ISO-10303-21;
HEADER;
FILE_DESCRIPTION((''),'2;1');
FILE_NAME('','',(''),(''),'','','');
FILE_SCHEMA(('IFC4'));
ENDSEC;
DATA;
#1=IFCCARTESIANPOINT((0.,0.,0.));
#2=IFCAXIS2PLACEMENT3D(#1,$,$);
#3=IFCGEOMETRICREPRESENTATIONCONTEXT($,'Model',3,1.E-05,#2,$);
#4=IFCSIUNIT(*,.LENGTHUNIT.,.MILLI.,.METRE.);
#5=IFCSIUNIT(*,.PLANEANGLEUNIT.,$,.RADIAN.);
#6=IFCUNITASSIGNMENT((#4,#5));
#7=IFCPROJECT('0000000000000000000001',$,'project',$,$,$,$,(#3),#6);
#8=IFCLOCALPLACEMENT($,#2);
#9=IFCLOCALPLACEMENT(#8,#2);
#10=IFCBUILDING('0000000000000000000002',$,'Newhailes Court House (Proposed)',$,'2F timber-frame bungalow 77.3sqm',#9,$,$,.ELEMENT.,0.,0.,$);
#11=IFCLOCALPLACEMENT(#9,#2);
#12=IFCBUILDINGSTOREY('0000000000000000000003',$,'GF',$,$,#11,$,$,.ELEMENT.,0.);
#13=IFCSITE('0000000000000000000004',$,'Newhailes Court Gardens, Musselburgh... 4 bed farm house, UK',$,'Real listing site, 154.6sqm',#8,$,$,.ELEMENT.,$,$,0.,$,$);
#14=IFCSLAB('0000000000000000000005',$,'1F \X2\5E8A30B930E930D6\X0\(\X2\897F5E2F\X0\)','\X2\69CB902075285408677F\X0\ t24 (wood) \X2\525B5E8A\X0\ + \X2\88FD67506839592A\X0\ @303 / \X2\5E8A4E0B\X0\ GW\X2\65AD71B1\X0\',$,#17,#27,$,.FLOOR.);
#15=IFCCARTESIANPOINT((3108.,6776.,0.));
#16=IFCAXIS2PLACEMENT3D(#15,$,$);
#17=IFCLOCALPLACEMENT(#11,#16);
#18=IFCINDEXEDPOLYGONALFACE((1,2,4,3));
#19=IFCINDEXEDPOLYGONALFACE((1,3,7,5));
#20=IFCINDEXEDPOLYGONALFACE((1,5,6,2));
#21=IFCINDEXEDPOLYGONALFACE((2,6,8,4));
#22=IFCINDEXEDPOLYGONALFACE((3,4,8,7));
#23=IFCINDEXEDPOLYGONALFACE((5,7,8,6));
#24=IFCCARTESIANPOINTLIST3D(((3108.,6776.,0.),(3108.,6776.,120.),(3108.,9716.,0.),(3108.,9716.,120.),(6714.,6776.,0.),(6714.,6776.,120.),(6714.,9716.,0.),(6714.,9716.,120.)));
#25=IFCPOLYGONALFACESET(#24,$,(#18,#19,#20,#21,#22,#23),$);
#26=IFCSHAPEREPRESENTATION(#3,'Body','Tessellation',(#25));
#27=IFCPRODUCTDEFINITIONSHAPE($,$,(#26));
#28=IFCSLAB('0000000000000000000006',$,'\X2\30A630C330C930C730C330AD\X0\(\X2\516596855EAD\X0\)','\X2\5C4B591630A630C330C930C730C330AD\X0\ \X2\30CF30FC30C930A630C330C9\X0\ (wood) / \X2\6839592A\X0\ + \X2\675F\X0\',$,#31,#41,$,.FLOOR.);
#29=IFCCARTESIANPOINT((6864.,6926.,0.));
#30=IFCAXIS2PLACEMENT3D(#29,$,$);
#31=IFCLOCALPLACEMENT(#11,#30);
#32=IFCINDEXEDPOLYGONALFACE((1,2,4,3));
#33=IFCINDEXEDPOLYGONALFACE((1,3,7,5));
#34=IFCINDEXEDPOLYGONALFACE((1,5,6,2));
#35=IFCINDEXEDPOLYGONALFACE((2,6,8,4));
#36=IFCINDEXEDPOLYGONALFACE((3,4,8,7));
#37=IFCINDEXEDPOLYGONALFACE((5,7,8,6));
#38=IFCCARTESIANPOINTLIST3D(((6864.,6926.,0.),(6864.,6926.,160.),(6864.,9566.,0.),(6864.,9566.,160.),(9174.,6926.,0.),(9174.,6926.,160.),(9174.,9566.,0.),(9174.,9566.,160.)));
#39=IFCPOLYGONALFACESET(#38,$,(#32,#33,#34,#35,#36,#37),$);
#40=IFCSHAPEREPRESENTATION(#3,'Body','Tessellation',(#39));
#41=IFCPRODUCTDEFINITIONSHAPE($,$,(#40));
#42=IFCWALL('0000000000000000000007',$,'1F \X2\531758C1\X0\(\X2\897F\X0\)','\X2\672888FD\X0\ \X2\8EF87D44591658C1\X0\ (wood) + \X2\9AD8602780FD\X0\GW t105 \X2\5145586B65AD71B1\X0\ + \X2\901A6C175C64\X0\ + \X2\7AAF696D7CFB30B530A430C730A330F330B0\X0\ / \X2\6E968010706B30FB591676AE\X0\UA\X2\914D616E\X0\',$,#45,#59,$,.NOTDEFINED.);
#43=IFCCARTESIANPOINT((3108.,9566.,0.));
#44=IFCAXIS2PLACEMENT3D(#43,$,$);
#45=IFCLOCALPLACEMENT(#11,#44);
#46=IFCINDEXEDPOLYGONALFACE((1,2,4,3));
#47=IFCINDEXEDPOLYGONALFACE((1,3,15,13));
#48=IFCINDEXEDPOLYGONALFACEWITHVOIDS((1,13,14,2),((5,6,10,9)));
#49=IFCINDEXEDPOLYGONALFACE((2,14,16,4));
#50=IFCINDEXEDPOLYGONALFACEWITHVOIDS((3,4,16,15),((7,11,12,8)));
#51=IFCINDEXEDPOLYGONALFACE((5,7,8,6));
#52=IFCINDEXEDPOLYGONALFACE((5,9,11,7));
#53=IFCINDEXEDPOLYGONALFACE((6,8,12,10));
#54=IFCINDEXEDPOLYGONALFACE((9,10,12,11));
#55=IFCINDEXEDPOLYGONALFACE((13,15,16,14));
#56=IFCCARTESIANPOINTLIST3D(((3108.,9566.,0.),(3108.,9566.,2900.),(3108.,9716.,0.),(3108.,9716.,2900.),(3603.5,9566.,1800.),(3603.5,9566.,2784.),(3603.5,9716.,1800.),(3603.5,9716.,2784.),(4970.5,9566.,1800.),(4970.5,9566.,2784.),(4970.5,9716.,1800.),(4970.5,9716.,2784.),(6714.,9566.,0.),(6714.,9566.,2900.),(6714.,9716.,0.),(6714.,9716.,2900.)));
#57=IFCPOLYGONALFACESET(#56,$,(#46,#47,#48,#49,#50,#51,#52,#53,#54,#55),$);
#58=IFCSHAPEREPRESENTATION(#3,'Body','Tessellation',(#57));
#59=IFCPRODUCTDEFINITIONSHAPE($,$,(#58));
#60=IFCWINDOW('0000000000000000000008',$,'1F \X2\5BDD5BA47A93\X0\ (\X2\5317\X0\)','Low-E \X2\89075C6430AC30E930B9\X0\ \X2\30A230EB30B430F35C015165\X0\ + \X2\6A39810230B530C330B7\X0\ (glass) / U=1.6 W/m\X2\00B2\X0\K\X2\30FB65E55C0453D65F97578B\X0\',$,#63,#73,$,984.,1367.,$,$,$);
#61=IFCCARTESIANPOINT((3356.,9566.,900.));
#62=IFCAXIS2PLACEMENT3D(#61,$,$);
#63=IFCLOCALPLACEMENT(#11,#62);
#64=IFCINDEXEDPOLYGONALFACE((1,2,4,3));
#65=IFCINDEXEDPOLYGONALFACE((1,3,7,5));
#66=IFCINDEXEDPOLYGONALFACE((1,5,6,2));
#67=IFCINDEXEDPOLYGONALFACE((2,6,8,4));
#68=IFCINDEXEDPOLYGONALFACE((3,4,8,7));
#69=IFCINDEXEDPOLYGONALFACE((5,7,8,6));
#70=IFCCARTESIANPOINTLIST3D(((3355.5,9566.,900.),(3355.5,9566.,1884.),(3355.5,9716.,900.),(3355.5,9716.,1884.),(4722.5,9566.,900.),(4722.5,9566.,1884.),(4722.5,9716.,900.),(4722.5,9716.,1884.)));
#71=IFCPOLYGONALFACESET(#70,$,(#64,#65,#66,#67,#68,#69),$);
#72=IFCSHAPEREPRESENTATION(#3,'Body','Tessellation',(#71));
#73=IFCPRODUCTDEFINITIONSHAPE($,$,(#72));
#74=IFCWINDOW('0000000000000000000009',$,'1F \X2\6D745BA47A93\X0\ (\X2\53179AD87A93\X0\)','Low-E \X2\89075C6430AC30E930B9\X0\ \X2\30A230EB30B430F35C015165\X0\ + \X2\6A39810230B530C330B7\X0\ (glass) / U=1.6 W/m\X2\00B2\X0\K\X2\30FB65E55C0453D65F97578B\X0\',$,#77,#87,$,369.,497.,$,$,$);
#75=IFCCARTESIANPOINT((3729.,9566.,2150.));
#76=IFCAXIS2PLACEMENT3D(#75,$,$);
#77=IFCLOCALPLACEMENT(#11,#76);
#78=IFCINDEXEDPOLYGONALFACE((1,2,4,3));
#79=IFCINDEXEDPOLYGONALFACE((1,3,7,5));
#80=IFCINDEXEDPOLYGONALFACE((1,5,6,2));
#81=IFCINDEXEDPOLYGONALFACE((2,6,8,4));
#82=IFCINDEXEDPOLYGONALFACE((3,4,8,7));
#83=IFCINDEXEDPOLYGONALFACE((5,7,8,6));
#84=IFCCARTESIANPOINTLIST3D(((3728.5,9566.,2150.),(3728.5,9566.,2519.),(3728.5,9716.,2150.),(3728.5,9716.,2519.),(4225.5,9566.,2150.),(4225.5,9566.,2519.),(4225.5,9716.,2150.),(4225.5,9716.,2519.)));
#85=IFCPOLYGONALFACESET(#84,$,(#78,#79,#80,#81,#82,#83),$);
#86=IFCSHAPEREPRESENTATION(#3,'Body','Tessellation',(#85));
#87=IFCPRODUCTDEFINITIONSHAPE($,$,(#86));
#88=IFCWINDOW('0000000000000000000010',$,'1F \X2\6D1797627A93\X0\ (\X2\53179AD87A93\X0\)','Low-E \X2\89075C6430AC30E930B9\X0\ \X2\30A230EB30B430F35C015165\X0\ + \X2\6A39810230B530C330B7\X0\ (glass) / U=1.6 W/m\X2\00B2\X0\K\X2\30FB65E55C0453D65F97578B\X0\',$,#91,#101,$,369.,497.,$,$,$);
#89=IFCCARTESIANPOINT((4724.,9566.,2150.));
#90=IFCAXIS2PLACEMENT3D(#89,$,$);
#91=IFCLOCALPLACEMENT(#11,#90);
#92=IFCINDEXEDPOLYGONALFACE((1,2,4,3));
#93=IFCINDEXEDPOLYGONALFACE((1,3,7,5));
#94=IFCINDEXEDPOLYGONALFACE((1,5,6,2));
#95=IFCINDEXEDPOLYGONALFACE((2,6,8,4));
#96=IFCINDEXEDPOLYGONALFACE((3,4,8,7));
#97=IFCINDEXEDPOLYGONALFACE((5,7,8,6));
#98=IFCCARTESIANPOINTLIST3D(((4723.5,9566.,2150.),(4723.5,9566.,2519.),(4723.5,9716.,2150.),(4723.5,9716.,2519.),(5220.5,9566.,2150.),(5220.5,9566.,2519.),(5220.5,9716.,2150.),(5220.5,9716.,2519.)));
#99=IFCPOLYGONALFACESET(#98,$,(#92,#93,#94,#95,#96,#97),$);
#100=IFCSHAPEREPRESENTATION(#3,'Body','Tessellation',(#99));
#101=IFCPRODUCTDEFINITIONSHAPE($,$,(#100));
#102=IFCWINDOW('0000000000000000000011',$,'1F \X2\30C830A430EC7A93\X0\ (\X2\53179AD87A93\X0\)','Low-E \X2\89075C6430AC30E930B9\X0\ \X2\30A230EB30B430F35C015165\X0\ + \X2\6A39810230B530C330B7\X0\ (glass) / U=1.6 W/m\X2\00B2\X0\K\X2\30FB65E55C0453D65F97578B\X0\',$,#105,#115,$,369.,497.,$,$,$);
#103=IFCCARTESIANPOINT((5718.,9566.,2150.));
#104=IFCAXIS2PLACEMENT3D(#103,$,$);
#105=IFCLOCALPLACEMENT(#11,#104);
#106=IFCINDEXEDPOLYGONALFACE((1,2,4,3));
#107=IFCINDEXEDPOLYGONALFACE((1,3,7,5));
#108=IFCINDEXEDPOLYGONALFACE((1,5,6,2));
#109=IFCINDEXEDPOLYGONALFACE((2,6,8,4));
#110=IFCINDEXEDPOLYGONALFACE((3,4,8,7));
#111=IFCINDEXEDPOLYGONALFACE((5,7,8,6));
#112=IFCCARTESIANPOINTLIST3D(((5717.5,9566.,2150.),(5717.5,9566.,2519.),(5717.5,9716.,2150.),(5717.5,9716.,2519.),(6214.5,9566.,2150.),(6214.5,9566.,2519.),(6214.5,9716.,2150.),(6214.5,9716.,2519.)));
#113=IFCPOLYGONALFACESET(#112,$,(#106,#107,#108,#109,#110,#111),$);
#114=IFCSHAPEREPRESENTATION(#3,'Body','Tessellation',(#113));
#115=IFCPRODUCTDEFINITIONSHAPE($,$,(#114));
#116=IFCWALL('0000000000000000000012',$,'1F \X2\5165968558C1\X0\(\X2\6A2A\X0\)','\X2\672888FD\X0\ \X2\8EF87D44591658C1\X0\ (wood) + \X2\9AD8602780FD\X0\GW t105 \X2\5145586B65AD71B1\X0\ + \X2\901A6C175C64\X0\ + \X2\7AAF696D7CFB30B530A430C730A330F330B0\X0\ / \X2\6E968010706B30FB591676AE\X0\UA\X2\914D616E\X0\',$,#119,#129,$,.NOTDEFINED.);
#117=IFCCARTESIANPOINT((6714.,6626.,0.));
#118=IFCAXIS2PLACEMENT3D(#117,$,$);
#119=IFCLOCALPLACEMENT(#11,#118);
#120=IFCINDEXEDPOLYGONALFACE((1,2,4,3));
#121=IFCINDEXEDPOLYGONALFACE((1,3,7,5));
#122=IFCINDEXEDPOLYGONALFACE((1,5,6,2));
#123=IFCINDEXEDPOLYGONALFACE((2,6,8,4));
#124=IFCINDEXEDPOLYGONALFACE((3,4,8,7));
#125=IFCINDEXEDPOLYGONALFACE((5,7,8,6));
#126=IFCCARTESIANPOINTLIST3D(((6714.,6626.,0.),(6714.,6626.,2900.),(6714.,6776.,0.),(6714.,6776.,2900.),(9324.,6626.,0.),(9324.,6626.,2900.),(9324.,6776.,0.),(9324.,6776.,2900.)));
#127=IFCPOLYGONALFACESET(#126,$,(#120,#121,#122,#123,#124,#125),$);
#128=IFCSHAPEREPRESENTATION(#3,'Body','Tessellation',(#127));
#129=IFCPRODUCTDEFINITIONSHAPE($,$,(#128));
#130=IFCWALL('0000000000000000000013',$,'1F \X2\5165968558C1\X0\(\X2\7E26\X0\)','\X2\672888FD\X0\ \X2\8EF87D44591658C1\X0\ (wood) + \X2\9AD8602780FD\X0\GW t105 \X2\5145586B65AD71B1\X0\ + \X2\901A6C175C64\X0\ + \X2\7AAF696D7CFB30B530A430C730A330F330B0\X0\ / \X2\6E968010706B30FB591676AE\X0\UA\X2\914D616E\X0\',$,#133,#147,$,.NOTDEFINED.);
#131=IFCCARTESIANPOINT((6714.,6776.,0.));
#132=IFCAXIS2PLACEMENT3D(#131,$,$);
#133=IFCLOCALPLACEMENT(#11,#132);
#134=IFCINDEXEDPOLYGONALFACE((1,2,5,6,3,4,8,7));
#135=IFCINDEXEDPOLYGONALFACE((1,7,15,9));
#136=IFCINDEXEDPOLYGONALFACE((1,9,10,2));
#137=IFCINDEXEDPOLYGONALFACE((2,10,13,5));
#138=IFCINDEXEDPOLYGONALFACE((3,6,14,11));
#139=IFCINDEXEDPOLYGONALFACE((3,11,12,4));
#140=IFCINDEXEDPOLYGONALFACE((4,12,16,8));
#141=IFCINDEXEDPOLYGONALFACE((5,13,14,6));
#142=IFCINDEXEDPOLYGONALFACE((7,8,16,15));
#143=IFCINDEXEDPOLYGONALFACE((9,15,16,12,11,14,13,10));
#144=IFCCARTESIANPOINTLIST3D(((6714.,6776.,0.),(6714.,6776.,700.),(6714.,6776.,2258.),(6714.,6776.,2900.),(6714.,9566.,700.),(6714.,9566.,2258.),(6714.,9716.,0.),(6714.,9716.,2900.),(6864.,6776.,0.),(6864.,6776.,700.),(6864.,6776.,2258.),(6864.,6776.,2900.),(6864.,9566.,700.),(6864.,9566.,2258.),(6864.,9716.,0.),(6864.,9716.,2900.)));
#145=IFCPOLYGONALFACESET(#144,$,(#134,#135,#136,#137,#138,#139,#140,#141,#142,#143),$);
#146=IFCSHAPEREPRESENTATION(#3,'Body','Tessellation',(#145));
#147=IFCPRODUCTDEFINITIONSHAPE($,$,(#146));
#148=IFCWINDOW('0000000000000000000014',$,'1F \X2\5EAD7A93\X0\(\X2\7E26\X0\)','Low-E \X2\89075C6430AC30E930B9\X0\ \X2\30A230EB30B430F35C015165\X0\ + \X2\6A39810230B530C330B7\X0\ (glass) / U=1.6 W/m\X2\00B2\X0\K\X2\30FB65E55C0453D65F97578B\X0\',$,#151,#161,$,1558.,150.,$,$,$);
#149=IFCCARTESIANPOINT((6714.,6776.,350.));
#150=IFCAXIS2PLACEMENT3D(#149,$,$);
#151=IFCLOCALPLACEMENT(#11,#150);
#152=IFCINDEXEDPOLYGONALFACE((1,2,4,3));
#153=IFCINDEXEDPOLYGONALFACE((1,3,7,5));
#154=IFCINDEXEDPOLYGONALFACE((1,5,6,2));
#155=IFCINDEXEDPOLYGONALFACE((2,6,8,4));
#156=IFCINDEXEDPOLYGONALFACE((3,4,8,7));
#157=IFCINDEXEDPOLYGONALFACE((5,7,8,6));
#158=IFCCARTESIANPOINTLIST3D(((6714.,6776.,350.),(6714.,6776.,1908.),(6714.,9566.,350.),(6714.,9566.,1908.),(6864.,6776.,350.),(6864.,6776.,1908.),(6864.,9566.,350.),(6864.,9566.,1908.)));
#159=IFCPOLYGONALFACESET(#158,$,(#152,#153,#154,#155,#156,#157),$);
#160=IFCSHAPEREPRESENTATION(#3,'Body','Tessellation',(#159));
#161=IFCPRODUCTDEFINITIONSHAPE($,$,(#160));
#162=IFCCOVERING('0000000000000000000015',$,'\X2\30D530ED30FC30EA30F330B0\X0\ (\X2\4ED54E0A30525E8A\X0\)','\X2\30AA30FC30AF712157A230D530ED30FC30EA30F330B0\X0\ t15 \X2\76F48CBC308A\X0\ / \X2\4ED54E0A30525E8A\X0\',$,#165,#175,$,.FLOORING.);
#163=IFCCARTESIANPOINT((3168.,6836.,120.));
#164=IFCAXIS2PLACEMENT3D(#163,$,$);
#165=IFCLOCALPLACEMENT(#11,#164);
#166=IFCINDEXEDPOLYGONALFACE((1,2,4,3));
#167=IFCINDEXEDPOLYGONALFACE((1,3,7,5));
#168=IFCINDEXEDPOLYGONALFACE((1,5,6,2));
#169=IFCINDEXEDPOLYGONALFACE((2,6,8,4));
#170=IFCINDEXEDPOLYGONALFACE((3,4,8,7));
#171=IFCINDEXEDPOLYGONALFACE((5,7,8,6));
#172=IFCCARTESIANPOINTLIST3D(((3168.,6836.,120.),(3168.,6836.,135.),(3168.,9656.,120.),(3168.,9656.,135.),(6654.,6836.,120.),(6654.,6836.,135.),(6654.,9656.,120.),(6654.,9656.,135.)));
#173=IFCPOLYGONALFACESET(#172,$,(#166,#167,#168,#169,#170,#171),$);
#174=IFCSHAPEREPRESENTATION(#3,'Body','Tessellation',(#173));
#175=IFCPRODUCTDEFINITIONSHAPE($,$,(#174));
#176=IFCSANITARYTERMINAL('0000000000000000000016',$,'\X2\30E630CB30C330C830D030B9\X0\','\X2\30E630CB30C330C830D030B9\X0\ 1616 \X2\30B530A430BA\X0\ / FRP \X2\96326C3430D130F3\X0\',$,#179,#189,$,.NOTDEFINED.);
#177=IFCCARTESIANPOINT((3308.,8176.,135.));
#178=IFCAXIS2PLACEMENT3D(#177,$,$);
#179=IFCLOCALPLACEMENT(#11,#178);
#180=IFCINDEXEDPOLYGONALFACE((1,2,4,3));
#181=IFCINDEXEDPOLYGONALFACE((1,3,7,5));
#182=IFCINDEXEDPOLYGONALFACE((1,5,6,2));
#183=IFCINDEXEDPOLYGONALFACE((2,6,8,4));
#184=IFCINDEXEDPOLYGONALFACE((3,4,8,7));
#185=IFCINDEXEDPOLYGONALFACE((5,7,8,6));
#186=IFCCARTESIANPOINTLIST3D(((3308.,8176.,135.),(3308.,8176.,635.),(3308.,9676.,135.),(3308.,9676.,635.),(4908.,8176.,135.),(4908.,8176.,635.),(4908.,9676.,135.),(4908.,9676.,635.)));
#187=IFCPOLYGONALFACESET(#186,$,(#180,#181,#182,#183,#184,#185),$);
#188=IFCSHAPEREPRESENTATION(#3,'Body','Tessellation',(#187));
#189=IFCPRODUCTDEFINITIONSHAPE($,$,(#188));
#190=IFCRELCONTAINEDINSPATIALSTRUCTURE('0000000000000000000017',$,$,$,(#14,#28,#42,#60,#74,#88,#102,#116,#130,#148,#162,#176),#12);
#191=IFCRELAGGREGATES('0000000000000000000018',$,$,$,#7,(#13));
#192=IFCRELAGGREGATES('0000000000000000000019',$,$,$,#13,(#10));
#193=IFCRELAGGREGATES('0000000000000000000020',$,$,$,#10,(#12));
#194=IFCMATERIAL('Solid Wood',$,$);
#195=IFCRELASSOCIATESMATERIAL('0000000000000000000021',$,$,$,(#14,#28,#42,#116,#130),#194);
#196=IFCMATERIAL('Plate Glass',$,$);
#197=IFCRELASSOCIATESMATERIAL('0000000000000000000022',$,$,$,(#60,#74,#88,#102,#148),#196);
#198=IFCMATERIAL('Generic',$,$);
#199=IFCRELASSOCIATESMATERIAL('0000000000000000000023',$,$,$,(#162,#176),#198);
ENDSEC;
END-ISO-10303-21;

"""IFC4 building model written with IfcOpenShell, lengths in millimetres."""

from ifc_helpers import new_model, si_unit, frame, frame_2d, origin, place, context, project, spatial, rectangle, extrude, material, element, fill, save


model = new_model("IFC4")

# Units and contexts
model_context = context("Model", 3, precision=1e-05, world=origin())
ifc_project = project(units=[si_unit("LENGTHUNIT", "METRE", prefix="MILLI"), si_unit("PLANEANGLEUNIT", "RADIAN")], contexts=[model_context])

# Site, building, storey
site_placement = place(None, origin())
site = spatial("IfcSite", under=ifc_project, at=site_placement, Name="Newhailes Court Gardens, Musselburgh... 4 bed farm house, UK", ObjectType="Real listing site, 154.6sqm", CompositionType="ELEMENT", RefElevation=0.0)
building_placement = place(site_placement, origin())
building = spatial("IfcBuilding", under=site, at=building_placement, Name="Newhailes Court House (Proposed)", ObjectType="2F timber-frame bungalow 77.3sqm", CompositionType="ELEMENT", ElevationOfRefHeight=0.0, ElevationOfTerrain=0.0)
storey_placement = place(building_placement, origin())
storey = spatial("IfcBuildingStorey", under=building, at=storey_placement, Name="GF", CompositionType="ELEMENT", Elevation=0.0)

# Slabs
ifc_material_1 = material(Name="Solid Wood")
slab_1_placement = place(storey_placement, frame((3108.0, 6776.0, 0.0)))
element("IfcSlab", 1, at=slab_1_placement, inside=storey, material=ifc_material_1, Name="1F 床スラブ(西帯)", Description="構造用合板 t24 (wood) 剛床 + 製材根太 @303 / 床下 GW断熱", PredefinedType="FLOOR", context=model_context, shape_type="SweptSolid", body=[
    extrude(rectangle(XDim=3606.0, YDim=2940.0, at=frame_2d((1803.0, 1470.0))), frame((3108.0, 6776.0, 0.0)), (0.0, 0.0, 1.0), 120.0),
])
slab_2_placement = place(storey_placement, frame((6864.0, 6926.0, 0.0)))
element("IfcSlab", 2, at=slab_2_placement, inside=storey, material=ifc_material_1, Name="ウッドデッキ(入隅庭)", Description="屋外ウッドデッキ ハードウッド (wood) / 根太 + 束", PredefinedType="FLOOR", context=model_context, shape_type="SweptSolid", body=[
    extrude(rectangle(XDim=2310.0, YDim=2640.0, at=frame_2d((1155.0, 1320.0))), frame((6864.0, 6926.0, 0.0)), (0.0, 0.0, 1.0), 160.0),
])

# Wall, openings, windows
wall_1_placement = place(storey_placement, frame((3108.0, 9566.0, 0.0)))
wall_1 = element("IfcWall", 3, at=wall_1_placement, inside=storey, material=ifc_material_1, Name="1F 北壁(西)", Description="木製 軸組外壁 (wood) + 高性能GW t105 充填断熱 + 通気層 + 窯業系サイディング / 準耐火・外皮UA配慮", PredefinedType="NOTDEFINED", context=model_context, shape_type="SweptSolid", body=[
    extrude(rectangle(XDim=3606.0, YDim=150.0, at=frame_2d((1803.0, 75.0))), frame((3108.0, 9566.0, 0.0)), (0.0, 0.0, 1.0), 2900.0),
])
opening_1_placement = place(storey_placement, frame((3356.0, 9566.0, 900.0)))
opening_1 = element("IfcOpeningElement", 4, at=opening_1_placement, cuts=wall_1, PredefinedType="NOTDEFINED", context=model_context, shape_type="SweptSolid", body=[
    extrude(rectangle(XDim=1367.0, YDim=150.0, at=frame_2d((683.0, 75.0))), frame((3356.0, 9566.0, 900.0)), (0.0, 0.0, 1.0), 984.0),
])
opening_2_placement = place(storey_placement, frame((3729.0, 9566.0, 2150.0)))
opening_2 = element("IfcOpeningElement", 5, at=opening_2_placement, cuts=wall_1, PredefinedType="NOTDEFINED", context=model_context, shape_type="SweptSolid", body=[
    extrude(rectangle(XDim=497.0, YDim=150.0, at=frame_2d((248.0, 75.0))), frame((3729.0, 9566.0, 2150.0)), (0.0, 0.0, 1.0), 369.0),
])
opening_3_placement = place(storey_placement, frame((4724.0, 9566.0, 2150.0)))
opening_3 = element("IfcOpeningElement", 6, at=opening_3_placement, cuts=wall_1, PredefinedType="NOTDEFINED", context=model_context, shape_type="SweptSolid", body=[
    extrude(rectangle(XDim=497.0, YDim=150.0, at=frame_2d((248.0, 75.0))), frame((4724.0, 9566.0, 2150.0)), (0.0, 0.0, 1.0), 369.0),
])
opening_4_placement = place(storey_placement, frame((5718.0, 9566.0, 2150.0)))
opening_4 = element("IfcOpeningElement", 7, at=opening_4_placement, cuts=wall_1, PredefinedType="NOTDEFINED", context=model_context, shape_type="SweptSolid", body=[
    extrude(rectangle(XDim=497.0, YDim=150.0, at=frame_2d((248.0, 75.0))), frame((5718.0, 9566.0, 2150.0)), (0.0, 0.0, 1.0), 369.0),
])
ifc_material_2 = material(Name="Plate Glass")
window_1_placement = place(storey_placement, frame((3356.0, 9566.0, 900.0)))
window_1 = element("IfcWindow", 8, at=window_1_placement, inside=storey, material=ifc_material_2, Name="1F 寝室窓 (北)", Description="Low-E 複層ガラス アルゴン封入 + 樹脂サッシ (glass) / U=1.6 W/m²K・日射取得型", OverallHeight=984.0, OverallWidth=1367.0, context=model_context, shape_type="SweptSolid", body=[
    extrude(rectangle(XDim=1367.0, YDim=150.0, at=frame_2d((683.0, 75.0))), frame((3356.0, 9566.0, 900.0)), (0.0, 0.0, 1.0), 984.0),
])
fill(opening_1, window_1)
window_2_placement = place(storey_placement, frame((3729.0, 9566.0, 2150.0)))
window_2 = element("IfcWindow", 9, at=window_2_placement, inside=storey, material=ifc_material_2, Name="1F 浴室窓 (北高窓)", Description="Low-E 複層ガラス アルゴン封入 + 樹脂サッシ (glass) / U=1.6 W/m²K・日射取得型", OverallHeight=369.0, OverallWidth=497.0, context=model_context, shape_type="SweptSolid", body=[
    extrude(rectangle(XDim=497.0, YDim=150.0, at=frame_2d((248.0, 75.0))), frame((3729.0, 9566.0, 2150.0)), (0.0, 0.0, 1.0), 369.0),
])
fill(opening_2, window_2)
window_3_placement = place(storey_placement, frame((4724.0, 9566.0, 2150.0)))
window_3 = element("IfcWindow", 10, at=window_3_placement, inside=storey, material=ifc_material_2, Name="1F 洗面窓 (北高窓)", Description="Low-E 複層ガラス アルゴン封入 + 樹脂サッシ (glass) / U=1.6 W/m²K・日射取得型", OverallHeight=369.0, OverallWidth=497.0, context=model_context, shape_type="SweptSolid", body=[
    extrude(rectangle(XDim=497.0, YDim=150.0, at=frame_2d((248.0, 75.0))), frame((4724.0, 9566.0, 2150.0)), (0.0, 0.0, 1.0), 369.0),
])
fill(opening_3, window_3)
window_4_placement = place(storey_placement, frame((5718.0, 9566.0, 2150.0)))
window_4 = element("IfcWindow", 11, at=window_4_placement, inside=storey, material=ifc_material_2, Name="1F トイレ窓 (北高窓)", Description="Low-E 複層ガラス アルゴン封入 + 樹脂サッシ (glass) / U=1.6 W/m²K・日射取得型", OverallHeight=369.0, OverallWidth=497.0, context=model_context, shape_type="SweptSolid", body=[
    extrude(rectangle(XDim=497.0, YDim=150.0, at=frame_2d((248.0, 75.0))), frame((5718.0, 9566.0, 2150.0)), (0.0, 0.0, 1.0), 369.0),
])
fill(opening_4, window_4)

# Wall
wall_2_placement = place(storey_placement, frame((6714.0, 6626.0, 0.0)))
element("IfcWall", 12, at=wall_2_placement, inside=storey, material=ifc_material_1, Name="1F 入隅壁(横)", Description="木製 軸組外壁 (wood) + 高性能GW t105 充填断熱 + 通気層 + 窯業系サイディング / 準耐火・外皮UA配慮", PredefinedType="NOTDEFINED", context=model_context, shape_type="SweptSolid", body=[
    extrude(rectangle(XDim=2610.0, YDim=150.0, at=frame_2d((1305.0, 75.0))), frame((6714.0, 6626.0, 0.0)), (0.0, 0.0, 1.0), 2900.0),
])

# Wall, opening, window
wall_3_placement = place(storey_placement, frame((6714.0, 6776.0, 0.0)))
wall_3 = element("IfcWall", 13, at=wall_3_placement, inside=storey, material=ifc_material_1, Name="1F 入隅壁(縦)", Description="木製 軸組外壁 (wood) + 高性能GW t105 充填断熱 + 通気層 + 窯業系サイディング / 準耐火・外皮UA配慮", PredefinedType="NOTDEFINED", context=model_context, shape_type="SweptSolid", body=[
    extrude(rectangle(XDim=150.0, YDim=2940.0, at=frame_2d((75.0, 1470.0))), frame((6714.0, 6776.0, 0.0)), (0.0, 0.0, 1.0), 2900.0),
])
opening_5_placement = place(storey_placement, frame((6714.0, 6776.0, 350.0)))
opening_5 = element("IfcOpeningElement", 14, at=opening_5_placement, cuts=wall_3, PredefinedType="NOTDEFINED", context=model_context, shape_type="SweptSolid", body=[
    extrude(rectangle(XDim=150.0, YDim=2790.0, at=frame_2d((75.0, 1395.0))), frame((6714.0, 6776.0, 350.0)), (0.0, 0.0, 1.0), 1558.0),
])
window_5_placement = place(storey_placement, frame((6714.0, 6776.0, 350.0)))
window_5 = element("IfcWindow", 15, at=window_5_placement, inside=storey, material=ifc_material_2, Name="1F 庭窓(縦)", Description="Low-E 複層ガラス アルゴン封入 + 樹脂サッシ (glass) / U=1.6 W/m²K・日射取得型", OverallHeight=1558.0, OverallWidth=150.0, context=model_context, shape_type="SweptSolid", body=[
    extrude(rectangle(XDim=150.0, YDim=2790.0, at=frame_2d((75.0, 1395.0))), frame((6714.0, 6776.0, 350.0)), (0.0, 0.0, 1.0), 1558.0),
])
fill(opening_5, window_5)

# Covering
ifc_material_3 = material(Name="Generic")
covering_placement = place(storey_placement, frame((3168.0, 6836.0, 120.0)))
element("IfcCovering", 16, at=covering_placement, inside=storey, material=ifc_material_3, Name="フローリング (仕上げ床)", Description="オーク無垢フローリング t15 直貼り / 仕上げ床", PredefinedType="FLOORING", context=model_context, shape_type="SweptSolid", body=[
    extrude(rectangle(XDim=3486.0, YDim=2820.0, at=frame_2d((1743.0, 1410.0))), frame((3168.0, 6836.0, 120.0)), (0.0, 0.0, 1.0), 15.0),
])

# Sanitary terminal
sanitary_terminal_1_placement = place(storey_placement, frame((3308.0, 8176.0, 135.0)))
element("IfcSanitaryTerminal", 17, at=sanitary_terminal_1_placement, inside=storey, material=ifc_material_3, Name="ユニットバス", Description="ユニットバス 1616 サイズ / FRP 防水パン", PredefinedType="NOTDEFINED", context=model_context, shape_type="SweptSolid", body=[
    extrude(rectangle(XDim=1600.0, YDim=1500.0, at=frame_2d((800.0, 750.0))), frame((3308.0, 8176.0, 135.0)), (0.0, 0.0, 1.0), 500.0),
])

save(model, "model.ifc")
